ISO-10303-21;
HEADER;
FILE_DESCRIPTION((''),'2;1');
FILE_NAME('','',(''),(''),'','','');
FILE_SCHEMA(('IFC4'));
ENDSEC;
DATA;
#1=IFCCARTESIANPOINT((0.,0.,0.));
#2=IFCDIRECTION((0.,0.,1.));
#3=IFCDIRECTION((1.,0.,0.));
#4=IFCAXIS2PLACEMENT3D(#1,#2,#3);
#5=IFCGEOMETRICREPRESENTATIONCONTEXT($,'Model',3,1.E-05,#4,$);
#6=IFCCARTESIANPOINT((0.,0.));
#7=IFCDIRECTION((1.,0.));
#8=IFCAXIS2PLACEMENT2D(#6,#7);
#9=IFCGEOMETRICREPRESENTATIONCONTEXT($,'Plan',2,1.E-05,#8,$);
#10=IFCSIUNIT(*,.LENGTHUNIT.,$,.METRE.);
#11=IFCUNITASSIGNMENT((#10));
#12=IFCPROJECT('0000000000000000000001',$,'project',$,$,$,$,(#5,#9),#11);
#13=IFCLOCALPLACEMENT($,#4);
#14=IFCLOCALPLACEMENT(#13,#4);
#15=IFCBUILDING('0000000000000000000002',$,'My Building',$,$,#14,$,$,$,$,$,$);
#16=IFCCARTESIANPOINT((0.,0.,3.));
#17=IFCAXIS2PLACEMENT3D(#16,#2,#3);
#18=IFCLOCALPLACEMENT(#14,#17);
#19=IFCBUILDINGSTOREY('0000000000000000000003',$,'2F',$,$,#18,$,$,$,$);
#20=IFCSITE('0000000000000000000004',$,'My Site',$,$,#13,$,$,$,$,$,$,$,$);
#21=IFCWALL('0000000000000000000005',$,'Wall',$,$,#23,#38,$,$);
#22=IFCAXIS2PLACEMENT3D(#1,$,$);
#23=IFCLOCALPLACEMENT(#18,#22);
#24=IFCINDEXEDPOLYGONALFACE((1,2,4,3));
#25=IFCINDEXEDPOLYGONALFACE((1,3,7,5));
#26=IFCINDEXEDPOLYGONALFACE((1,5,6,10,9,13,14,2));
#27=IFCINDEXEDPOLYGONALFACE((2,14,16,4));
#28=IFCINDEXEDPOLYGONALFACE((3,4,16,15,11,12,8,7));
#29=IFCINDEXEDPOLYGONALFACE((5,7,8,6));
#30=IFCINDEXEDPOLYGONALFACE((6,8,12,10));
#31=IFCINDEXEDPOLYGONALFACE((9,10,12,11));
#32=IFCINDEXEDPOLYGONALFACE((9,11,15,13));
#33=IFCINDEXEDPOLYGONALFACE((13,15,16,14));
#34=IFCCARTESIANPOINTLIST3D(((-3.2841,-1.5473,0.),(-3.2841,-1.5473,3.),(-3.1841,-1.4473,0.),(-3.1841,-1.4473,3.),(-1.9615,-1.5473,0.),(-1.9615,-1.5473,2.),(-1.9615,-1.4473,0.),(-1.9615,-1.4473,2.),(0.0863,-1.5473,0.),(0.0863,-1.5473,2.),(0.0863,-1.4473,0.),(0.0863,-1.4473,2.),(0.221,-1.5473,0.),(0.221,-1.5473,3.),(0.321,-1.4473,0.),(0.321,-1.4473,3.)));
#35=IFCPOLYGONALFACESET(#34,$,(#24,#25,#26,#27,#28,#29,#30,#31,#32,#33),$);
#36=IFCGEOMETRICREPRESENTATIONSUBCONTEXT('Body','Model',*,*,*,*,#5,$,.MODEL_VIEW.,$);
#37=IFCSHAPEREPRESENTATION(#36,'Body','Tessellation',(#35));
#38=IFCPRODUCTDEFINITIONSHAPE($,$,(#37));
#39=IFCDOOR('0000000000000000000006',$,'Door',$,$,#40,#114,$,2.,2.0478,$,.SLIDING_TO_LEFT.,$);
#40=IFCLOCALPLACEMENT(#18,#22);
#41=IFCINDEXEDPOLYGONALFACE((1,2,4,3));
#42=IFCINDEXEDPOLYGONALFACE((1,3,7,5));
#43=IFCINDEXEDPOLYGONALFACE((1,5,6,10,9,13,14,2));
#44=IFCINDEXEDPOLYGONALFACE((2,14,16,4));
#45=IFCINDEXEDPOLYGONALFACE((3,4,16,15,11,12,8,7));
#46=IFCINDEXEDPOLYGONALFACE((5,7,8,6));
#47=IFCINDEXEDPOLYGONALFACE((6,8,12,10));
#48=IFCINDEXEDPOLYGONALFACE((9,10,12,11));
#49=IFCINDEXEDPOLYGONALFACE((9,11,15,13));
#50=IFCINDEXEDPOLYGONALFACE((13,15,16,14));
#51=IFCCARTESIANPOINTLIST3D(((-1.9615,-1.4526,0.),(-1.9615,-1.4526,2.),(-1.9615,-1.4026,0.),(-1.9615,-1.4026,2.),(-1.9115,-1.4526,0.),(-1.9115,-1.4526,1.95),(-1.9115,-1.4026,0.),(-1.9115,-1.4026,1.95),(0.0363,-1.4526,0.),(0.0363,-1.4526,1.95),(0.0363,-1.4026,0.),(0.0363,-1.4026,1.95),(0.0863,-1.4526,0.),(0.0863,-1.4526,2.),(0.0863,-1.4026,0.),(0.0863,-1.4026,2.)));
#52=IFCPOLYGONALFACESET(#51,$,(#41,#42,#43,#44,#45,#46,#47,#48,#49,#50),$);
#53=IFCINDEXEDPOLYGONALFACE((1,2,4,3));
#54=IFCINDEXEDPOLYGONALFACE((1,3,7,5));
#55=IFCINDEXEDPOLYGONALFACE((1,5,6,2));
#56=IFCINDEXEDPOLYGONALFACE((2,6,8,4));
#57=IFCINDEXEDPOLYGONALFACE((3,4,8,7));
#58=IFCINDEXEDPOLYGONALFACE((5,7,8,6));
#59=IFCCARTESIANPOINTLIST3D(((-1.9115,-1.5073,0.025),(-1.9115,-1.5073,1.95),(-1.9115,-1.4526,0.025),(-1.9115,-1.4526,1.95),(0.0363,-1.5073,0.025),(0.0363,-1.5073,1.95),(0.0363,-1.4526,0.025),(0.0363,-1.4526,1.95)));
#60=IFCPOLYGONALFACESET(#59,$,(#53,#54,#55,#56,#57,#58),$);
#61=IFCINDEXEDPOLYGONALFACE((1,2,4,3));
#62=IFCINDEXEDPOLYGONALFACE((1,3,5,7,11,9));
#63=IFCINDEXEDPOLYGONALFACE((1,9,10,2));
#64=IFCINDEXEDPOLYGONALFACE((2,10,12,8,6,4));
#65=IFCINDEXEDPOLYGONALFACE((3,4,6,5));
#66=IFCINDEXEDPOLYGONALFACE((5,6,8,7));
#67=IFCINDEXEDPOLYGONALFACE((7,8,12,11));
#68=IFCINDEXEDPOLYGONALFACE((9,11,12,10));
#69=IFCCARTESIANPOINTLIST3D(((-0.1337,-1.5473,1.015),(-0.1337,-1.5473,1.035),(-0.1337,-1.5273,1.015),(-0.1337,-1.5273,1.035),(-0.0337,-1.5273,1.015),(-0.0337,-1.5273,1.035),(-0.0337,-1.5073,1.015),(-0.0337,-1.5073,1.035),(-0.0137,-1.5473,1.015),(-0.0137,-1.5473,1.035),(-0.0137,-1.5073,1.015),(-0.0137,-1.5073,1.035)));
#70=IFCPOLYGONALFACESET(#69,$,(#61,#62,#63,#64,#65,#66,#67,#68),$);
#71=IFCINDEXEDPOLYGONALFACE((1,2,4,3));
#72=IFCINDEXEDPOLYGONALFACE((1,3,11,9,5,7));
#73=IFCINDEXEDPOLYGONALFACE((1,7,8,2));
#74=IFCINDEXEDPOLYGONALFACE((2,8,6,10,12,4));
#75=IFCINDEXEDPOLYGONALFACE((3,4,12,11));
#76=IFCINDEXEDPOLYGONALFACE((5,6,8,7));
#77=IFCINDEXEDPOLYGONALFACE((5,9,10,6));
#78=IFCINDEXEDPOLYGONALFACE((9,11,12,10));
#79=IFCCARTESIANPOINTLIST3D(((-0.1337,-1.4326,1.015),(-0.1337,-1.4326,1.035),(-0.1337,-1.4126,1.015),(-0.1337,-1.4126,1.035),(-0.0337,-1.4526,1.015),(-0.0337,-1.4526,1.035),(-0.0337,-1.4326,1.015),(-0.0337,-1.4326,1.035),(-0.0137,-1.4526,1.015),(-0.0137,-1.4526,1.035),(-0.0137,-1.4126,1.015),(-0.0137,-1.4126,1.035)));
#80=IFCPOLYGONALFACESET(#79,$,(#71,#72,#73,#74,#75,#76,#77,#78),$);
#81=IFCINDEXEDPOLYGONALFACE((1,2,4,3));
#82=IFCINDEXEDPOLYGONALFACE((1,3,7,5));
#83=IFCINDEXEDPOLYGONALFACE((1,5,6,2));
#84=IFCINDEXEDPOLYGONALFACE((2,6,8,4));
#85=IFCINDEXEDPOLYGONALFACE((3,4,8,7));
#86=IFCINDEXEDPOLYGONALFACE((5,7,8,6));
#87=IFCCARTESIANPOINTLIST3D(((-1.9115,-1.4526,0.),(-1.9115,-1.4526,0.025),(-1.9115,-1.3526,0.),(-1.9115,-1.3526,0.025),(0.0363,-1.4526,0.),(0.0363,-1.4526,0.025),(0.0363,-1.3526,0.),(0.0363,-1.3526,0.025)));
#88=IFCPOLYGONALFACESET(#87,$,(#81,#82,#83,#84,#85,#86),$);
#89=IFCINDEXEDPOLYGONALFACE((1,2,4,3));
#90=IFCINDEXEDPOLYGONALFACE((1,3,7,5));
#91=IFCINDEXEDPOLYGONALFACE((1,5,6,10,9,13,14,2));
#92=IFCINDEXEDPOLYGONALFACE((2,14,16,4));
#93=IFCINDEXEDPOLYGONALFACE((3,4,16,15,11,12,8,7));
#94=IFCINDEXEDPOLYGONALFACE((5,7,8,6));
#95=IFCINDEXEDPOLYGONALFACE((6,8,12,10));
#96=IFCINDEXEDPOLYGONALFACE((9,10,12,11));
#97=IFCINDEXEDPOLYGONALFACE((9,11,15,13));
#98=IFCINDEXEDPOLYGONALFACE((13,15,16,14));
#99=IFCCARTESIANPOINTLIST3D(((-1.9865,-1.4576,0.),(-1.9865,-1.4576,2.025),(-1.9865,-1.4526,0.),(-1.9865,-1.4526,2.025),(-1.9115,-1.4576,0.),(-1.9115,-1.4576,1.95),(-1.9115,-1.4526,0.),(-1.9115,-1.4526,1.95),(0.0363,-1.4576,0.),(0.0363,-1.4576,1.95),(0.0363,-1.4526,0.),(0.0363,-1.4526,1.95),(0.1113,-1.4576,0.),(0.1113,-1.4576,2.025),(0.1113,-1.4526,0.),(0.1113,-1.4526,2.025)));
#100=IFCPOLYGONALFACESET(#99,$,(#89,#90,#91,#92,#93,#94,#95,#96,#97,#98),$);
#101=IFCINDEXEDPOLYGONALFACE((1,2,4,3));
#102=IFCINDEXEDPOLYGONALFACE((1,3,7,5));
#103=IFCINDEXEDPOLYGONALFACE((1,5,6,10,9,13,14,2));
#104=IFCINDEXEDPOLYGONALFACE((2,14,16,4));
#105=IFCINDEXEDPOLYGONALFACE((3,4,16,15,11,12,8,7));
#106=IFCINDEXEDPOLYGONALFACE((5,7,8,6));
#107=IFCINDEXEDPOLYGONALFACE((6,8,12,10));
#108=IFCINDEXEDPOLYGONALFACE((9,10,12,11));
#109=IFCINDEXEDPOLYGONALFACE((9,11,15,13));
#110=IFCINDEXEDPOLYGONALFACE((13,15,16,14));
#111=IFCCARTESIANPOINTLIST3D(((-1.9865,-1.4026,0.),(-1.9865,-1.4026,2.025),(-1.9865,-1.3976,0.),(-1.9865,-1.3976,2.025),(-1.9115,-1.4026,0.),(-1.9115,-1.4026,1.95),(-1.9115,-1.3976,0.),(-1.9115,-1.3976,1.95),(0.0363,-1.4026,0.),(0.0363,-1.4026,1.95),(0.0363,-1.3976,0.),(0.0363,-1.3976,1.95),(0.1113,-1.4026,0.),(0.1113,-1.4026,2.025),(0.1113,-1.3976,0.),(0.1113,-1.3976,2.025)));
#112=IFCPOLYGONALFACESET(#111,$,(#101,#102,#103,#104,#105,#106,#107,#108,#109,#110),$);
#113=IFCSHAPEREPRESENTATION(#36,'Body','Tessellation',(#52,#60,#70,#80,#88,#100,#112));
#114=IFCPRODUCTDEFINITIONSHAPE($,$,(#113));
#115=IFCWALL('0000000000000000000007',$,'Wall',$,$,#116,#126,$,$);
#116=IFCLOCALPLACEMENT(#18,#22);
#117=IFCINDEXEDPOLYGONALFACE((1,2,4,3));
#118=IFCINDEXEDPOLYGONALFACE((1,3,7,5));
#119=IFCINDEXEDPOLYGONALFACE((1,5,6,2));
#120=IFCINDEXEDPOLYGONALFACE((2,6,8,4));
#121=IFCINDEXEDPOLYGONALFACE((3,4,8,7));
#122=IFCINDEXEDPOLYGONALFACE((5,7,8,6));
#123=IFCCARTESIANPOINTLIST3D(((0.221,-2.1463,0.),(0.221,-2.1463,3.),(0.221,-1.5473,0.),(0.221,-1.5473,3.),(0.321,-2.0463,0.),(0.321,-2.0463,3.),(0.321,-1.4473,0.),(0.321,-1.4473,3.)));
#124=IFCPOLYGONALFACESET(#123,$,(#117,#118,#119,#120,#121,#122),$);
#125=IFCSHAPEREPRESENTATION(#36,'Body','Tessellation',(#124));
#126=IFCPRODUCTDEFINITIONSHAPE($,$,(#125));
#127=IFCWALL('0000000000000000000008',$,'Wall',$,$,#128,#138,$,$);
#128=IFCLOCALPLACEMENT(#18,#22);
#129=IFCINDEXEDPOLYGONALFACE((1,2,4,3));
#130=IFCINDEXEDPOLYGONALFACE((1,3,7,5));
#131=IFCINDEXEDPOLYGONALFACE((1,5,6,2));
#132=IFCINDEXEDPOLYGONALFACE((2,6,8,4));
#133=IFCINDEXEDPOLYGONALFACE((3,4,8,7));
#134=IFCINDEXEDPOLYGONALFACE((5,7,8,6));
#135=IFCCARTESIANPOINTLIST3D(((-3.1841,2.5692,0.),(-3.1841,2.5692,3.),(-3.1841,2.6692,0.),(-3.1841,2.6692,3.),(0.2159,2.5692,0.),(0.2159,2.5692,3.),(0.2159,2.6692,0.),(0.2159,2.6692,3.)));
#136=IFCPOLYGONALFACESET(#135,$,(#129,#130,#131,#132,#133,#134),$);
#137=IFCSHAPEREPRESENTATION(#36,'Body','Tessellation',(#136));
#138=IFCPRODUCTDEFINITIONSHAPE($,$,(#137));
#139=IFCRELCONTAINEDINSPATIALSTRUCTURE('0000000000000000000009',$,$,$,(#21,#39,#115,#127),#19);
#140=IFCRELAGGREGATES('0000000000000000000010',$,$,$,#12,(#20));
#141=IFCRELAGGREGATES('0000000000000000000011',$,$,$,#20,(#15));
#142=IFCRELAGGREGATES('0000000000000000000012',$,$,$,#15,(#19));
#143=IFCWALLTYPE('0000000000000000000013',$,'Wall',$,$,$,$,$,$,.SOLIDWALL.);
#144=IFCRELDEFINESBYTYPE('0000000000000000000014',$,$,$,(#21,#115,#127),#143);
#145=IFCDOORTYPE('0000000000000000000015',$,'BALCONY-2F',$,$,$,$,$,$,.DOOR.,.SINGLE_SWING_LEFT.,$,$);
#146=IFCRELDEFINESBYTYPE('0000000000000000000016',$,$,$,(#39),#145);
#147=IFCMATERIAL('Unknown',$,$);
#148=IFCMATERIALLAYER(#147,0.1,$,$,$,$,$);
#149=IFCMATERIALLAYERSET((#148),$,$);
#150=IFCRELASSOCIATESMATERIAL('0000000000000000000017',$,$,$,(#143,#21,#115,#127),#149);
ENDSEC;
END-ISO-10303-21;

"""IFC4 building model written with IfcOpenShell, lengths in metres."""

from ifc_helpers import new_model, entity, si_unit, frame, origin_with_axes, origin_2d_with_axis, place, context, subcontext, project, spatial, line, indexed_curve, outline, extrude, shape, source, transform, mapped, material, layer, layer_set, layer_usage, type_object, type_shapes, element, fill, save


model = new_model("IFC4")

# Units and contexts
model_context = context("Model", 3, precision=1e-05, world=origin_with_axes())
plan_context = context("Plan", 2, precision=1e-05, world=origin_2d_with_axis())
body_context_1 = subcontext(model_context, "Body", "Model", "MODEL_VIEW")
body_context_2 = subcontext(plan_context, "Body", "Plan", "PLAN_VIEW")
ifc_project = project(units=[si_unit("LENGTHUNIT", "METRE")], contexts=[model_context, plan_context])

# Site, building, storey
site_placement = place(None, origin_with_axes())
site = spatial("IfcSite", under=ifc_project, at=site_placement, Name="My Site")
building_placement = place(site_placement, origin_with_axes())
building = spatial("IfcBuilding", under=site, at=building_placement, Name="My Building")
storey_placement = place(building_placement, frame((0.0, 0.0, 3.0), z_axis=(0.0, 0.0, 1.0), x_axis=(1.0, 0.0, 0.0)))
storey = spatial("IfcBuildingStorey", under=building, at=storey_placement, Name="2F")

# Shared definitions
ifc_material_1 = material(Name="Unknown")

# Shared definitions
ifc_layer_1 = layer(ifc_material_1, 0.1)
ifc_layer_set_1 = layer_set([ifc_layer_1])
wall_type = type_object("IfcWallType", Name="Wall", PredefinedType="SOLIDWALL", material=ifc_layer_set_1)

# Wall, opening, door
ifc_layer_usage_1 = layer_usage(ifc_layer_set_1, "AXIS2", "POSITIVE", 0.0)
wall_1_placement = place(storey_placement, frame((-3.2841, -1.5473, 0.0), z_axis=(0.0, 0.0, 1.0), x_axis=(1.0, 0.0, 0.0)))
wall_1 = element("IfcWall", 1, at=wall_1_placement, inside=storey, type_object=wall_type, material=ifc_layer_usage_1, Name="Wall", context=body_context_1, shape_type="SweptSolid", body=[
    extrude(outline(indexed_curve([(0.0, 0.0), (0.1, 0.1), (3.6052, 0.1), (3.5052, 0.0)], segments=[line(1, 2, 3, 4, 1)])), origin_with_axes(), (0.0, 0.0, 1.0), 3.0),
])
shared_shape_1 = source(origin_with_axes(), body_context_1, "Body", "SweptSolid", [
    extrude(outline(indexed_curve([(0.0, 0.0), (2.0478, 0.0), (2.0478, 2.0), (0.0, 2.0)], segments=[line(1, 2, 3, 4, 1)])), frame((0.0, -0.6, 0.0), z_axis=(0.0, -1.0, 0.0), x_axis=(1.0, 0.0, 0.0)), (0.0, 0.0, -1.0), 1.2),
])
opening_1_placement = place(wall_1_placement, frame((1.3226, 0.0947, 0.0), z_axis=(0.0, 0.0, 1.0), x_axis=(1.0, 0.0, 0.0)))
opening_1 = element("IfcOpeningElement", 2, at=opening_1_placement, cuts=wall_1, PredefinedType="OPENING", context=body_context_1, shape_type="MappedRepresentation", body=[
    mapped(shared_shape_1, transform((0.0, 0.0, 0.0), x_axis=(1.0, 0.0, 0.0), y_axis=(0.0, 1.0, 0.0), z_axis=(0.0, 0.0, 1.0), scale=1.0)),
])
door_type_1 = type_object("IfcDoorType", Name="BALCONY-2F", OperationType="SINGLE_SWING_LEFT", PredefinedType="DOOR")
shared_shape_2 = source(origin_with_axes(), body_context_1, "Body", "SweptSolid", [
    extrude(outline(indexed_curve([(0.0, 0.0), (0.0, 2.0), (2.0478, 2.0), (2.0478, 0.0), (1.9978, 0.0), (1.9978, 1.95), (0.05, 1.95), (0.05, 0.0)], segments=[line(1, 2, 3, 4, 5, 6, 7, 8, 1)])), frame((0.0, 0.0, 0.0), z_axis=(0.0, -1.0, 0.0), x_axis=(1.0, 0.0, 0.0)), (0.0, 0.0, -1.0), 0.05),
    extrude(outline(indexed_curve([(0.0, 0.0), (1.9478, 0.0), (1.9478, 0.0547), (0.0, 0.0547)], segments=[line(1, 2, 3, 4, 1)])), frame((0.05, -0.0547, 0.025), z_axis=(0.0, 0.0, 1.0), x_axis=(1.0, 0.0, 0.0)), (0.0, 0.0, 1.0), 1.925),
    extrude(outline(indexed_curve([(0.0, 0.0), (0.0, -0.04), (-0.12, -0.04), (-0.12, -0.02), (-0.02, -0.02), (-0.02, 0.0)], segments=[line(1, 2, 3, 4, 5, 6, 1)])), frame((1.9478, -0.0547, 1.015), z_axis=(0.0, 0.0, 1.0), x_axis=(1.0, 0.0, 0.0)), (0.0, 0.0, 1.0), 0.02),
    extrude(outline(indexed_curve([(0.0, 0.0), (0.0, 0.04), (-0.12, 0.04), (-0.12, 0.02), (-0.02, 0.02), (-0.02, 0.0)], segments=[line(1, 2, 3, 4, 5, 6, 1)])), frame((1.9478, 0.0, 1.015), z_axis=(0.0, 0.0, 1.0), x_axis=(1.0, 0.0, 0.0)), (0.0, 0.0, 1.0), 0.02),
    extrude(outline(indexed_curve([(0.0, 0.0), (1.9478, 0.0), (1.9478, 0.1), (0.0, 0.1)], segments=[line(1, 2, 3, 4, 1)])), frame((0.05, 0.0, 0.0), z_axis=(0.0, 0.0, 1.0), x_axis=(1.0, 0.0, 0.0)), (0.0, 0.0, 1.0), 0.025),
    extrude(outline(indexed_curve([(0.0, 0.0), (0.0, 2.025), (2.0978, 2.025), (2.0978, 0.0), (2.0228, 0.0), (2.0228, 1.95), (0.075, 1.95), (0.075, 0.0)], segments=[line(1, 2, 3, 4, 5, 6, 7, 8, 1)])), frame((-0.025, -0.005, 0.0), z_axis=(0.0, -1.0, 0.0), x_axis=(1.0, 0.0, 0.0)), (0.0, 0.0, -1.0), 0.005),
    extrude(outline(indexed_curve([(0.0, 0.0), (0.0, 2.025), (2.0978, 2.025), (2.0978, 0.0), (2.0228, 0.0), (2.0228, 1.95), (0.075, 1.95), (0.075, 0.0)], segments=[line(1, 2, 3, 4, 5, 6, 7, 8, 1)])), frame((-0.025, 0.05, 0.0), z_axis=(0.0, -1.0, 0.0), x_axis=(1.0, 0.0, 0.0)), (0.0, 0.0, -1.0), 0.005),
])
shared_shape_3 = source(origin_with_axes(), body_context_2, "Body", "Curve2D", [
    entity("IfcIndexedPolyCurve", entity("IfcCartesianPointList2D", [[0.0, 0.0], [0.05, 0.0], [0.05, 0.05], [0.0, 0.05]]), [entity("IfcLineIndex", [1, 2, 3, 4, 1])]),
    entity("IfcIndexedPolyCurve", entity("IfcCartesianPointList2D", [[2.0478, 0.0], [1.9978, 0.0], [1.9978, 0.05], [2.0478, 0.05]]), [entity("IfcLineIndex", [1, 2, 3, 4, 1])]),
    entity("IfcIndexedPolyCurve", entity("IfcCartesianPointList2D", [[-0.9239, -0.0547], [1.0239, -0.0547], [1.0239, 0.0], [-0.9239, 0.0]]), [entity("IfcLineIndex", [1, 2, 3, 4, 1])]),
])
type_shapes(door_type_1, [shared_shape_2, shared_shape_3])
door_1_placement = place(opening_1_placement, frame((0.0, 0.0, 0.0), z_axis=(0.0, 0.0, 1.0), x_axis=(1.0, 0.0, 0.0)))
door_1 = element("IfcDoor", 3, at=door_1_placement, inside=storey, type_object=door_type_1, Name="Door", OperationType="SLIDING_TO_LEFT", OverallHeight=2.0, OverallWidth=2.0478, shapes=[
    shape(body_context_1, "Body", "MappedRepresentation", [mapped(shared_shape_2, transform((0.0, 0.0, 0.0), x_axis=(1.0, 0.0, 0.0), y_axis=(0.0, 1.0, 0.0), z_axis=(0.0, 0.0, 1.0), scale=1.0))]),
    shape(body_context_2, "Body", "MappedRepresentation", [mapped(shared_shape_3, transform((0.0, 0.0, 0.0), x_axis=(1.0, 0.0, 0.0), y_axis=(0.0, 1.0, 0.0), z_axis=(0.0, 0.0, 1.0), scale=1.0))]),
])
fill(opening_1, door_1)

# Walls
ifc_layer_usage_2 = layer_usage(ifc_layer_set_1, "AXIS2", "POSITIVE", 0.0)
wall_2_placement = place(storey_placement, frame((0.221, -1.5473, 0.0), z_axis=(0.0, 0.0, 1.0), x_axis=(0.0, -1.0, 0.0)))
element("IfcWall", 4, at=wall_2_placement, inside=storey, type_object=wall_type, material=ifc_layer_usage_2, Name="Wall", context=body_context_1, shape_type="SweptSolid", body=[
    extrude(outline(indexed_curve([(0.0, 0.0), (-0.1, 0.1), (0.499, 0.1), (0.599, 0.0)], segments=[line(1, 2, 3, 4, 1)])), origin_with_axes(), (0.0, 0.0, 1.0), 3.0),
])
ifc_layer_usage_3 = layer_usage(ifc_layer_set_1, "AXIS2", "POSITIVE", 0.0)
wall_3_placement = place(storey_placement, frame((-3.1841, 2.5692, 0.0), z_axis=(0.0, 0.0, 1.0), x_axis=(1.0, 0.0, 0.0)))
element("IfcWall", 5, at=wall_3_placement, inside=storey, type_object=wall_type, material=ifc_layer_usage_3, Name="Wall", context=body_context_1, shape_type="SweptSolid", body=[
    extrude(outline(indexed_curve([(0.0, 0.0), (0.0, 0.1), (3.4, 0.1), (3.4, 0.0)], segments=[line(1, 2, 3, 4, 1)])), origin_with_axes(), (0.0, 0.0, 1.0), 3.0),
])

save(model, "model.ifc")
